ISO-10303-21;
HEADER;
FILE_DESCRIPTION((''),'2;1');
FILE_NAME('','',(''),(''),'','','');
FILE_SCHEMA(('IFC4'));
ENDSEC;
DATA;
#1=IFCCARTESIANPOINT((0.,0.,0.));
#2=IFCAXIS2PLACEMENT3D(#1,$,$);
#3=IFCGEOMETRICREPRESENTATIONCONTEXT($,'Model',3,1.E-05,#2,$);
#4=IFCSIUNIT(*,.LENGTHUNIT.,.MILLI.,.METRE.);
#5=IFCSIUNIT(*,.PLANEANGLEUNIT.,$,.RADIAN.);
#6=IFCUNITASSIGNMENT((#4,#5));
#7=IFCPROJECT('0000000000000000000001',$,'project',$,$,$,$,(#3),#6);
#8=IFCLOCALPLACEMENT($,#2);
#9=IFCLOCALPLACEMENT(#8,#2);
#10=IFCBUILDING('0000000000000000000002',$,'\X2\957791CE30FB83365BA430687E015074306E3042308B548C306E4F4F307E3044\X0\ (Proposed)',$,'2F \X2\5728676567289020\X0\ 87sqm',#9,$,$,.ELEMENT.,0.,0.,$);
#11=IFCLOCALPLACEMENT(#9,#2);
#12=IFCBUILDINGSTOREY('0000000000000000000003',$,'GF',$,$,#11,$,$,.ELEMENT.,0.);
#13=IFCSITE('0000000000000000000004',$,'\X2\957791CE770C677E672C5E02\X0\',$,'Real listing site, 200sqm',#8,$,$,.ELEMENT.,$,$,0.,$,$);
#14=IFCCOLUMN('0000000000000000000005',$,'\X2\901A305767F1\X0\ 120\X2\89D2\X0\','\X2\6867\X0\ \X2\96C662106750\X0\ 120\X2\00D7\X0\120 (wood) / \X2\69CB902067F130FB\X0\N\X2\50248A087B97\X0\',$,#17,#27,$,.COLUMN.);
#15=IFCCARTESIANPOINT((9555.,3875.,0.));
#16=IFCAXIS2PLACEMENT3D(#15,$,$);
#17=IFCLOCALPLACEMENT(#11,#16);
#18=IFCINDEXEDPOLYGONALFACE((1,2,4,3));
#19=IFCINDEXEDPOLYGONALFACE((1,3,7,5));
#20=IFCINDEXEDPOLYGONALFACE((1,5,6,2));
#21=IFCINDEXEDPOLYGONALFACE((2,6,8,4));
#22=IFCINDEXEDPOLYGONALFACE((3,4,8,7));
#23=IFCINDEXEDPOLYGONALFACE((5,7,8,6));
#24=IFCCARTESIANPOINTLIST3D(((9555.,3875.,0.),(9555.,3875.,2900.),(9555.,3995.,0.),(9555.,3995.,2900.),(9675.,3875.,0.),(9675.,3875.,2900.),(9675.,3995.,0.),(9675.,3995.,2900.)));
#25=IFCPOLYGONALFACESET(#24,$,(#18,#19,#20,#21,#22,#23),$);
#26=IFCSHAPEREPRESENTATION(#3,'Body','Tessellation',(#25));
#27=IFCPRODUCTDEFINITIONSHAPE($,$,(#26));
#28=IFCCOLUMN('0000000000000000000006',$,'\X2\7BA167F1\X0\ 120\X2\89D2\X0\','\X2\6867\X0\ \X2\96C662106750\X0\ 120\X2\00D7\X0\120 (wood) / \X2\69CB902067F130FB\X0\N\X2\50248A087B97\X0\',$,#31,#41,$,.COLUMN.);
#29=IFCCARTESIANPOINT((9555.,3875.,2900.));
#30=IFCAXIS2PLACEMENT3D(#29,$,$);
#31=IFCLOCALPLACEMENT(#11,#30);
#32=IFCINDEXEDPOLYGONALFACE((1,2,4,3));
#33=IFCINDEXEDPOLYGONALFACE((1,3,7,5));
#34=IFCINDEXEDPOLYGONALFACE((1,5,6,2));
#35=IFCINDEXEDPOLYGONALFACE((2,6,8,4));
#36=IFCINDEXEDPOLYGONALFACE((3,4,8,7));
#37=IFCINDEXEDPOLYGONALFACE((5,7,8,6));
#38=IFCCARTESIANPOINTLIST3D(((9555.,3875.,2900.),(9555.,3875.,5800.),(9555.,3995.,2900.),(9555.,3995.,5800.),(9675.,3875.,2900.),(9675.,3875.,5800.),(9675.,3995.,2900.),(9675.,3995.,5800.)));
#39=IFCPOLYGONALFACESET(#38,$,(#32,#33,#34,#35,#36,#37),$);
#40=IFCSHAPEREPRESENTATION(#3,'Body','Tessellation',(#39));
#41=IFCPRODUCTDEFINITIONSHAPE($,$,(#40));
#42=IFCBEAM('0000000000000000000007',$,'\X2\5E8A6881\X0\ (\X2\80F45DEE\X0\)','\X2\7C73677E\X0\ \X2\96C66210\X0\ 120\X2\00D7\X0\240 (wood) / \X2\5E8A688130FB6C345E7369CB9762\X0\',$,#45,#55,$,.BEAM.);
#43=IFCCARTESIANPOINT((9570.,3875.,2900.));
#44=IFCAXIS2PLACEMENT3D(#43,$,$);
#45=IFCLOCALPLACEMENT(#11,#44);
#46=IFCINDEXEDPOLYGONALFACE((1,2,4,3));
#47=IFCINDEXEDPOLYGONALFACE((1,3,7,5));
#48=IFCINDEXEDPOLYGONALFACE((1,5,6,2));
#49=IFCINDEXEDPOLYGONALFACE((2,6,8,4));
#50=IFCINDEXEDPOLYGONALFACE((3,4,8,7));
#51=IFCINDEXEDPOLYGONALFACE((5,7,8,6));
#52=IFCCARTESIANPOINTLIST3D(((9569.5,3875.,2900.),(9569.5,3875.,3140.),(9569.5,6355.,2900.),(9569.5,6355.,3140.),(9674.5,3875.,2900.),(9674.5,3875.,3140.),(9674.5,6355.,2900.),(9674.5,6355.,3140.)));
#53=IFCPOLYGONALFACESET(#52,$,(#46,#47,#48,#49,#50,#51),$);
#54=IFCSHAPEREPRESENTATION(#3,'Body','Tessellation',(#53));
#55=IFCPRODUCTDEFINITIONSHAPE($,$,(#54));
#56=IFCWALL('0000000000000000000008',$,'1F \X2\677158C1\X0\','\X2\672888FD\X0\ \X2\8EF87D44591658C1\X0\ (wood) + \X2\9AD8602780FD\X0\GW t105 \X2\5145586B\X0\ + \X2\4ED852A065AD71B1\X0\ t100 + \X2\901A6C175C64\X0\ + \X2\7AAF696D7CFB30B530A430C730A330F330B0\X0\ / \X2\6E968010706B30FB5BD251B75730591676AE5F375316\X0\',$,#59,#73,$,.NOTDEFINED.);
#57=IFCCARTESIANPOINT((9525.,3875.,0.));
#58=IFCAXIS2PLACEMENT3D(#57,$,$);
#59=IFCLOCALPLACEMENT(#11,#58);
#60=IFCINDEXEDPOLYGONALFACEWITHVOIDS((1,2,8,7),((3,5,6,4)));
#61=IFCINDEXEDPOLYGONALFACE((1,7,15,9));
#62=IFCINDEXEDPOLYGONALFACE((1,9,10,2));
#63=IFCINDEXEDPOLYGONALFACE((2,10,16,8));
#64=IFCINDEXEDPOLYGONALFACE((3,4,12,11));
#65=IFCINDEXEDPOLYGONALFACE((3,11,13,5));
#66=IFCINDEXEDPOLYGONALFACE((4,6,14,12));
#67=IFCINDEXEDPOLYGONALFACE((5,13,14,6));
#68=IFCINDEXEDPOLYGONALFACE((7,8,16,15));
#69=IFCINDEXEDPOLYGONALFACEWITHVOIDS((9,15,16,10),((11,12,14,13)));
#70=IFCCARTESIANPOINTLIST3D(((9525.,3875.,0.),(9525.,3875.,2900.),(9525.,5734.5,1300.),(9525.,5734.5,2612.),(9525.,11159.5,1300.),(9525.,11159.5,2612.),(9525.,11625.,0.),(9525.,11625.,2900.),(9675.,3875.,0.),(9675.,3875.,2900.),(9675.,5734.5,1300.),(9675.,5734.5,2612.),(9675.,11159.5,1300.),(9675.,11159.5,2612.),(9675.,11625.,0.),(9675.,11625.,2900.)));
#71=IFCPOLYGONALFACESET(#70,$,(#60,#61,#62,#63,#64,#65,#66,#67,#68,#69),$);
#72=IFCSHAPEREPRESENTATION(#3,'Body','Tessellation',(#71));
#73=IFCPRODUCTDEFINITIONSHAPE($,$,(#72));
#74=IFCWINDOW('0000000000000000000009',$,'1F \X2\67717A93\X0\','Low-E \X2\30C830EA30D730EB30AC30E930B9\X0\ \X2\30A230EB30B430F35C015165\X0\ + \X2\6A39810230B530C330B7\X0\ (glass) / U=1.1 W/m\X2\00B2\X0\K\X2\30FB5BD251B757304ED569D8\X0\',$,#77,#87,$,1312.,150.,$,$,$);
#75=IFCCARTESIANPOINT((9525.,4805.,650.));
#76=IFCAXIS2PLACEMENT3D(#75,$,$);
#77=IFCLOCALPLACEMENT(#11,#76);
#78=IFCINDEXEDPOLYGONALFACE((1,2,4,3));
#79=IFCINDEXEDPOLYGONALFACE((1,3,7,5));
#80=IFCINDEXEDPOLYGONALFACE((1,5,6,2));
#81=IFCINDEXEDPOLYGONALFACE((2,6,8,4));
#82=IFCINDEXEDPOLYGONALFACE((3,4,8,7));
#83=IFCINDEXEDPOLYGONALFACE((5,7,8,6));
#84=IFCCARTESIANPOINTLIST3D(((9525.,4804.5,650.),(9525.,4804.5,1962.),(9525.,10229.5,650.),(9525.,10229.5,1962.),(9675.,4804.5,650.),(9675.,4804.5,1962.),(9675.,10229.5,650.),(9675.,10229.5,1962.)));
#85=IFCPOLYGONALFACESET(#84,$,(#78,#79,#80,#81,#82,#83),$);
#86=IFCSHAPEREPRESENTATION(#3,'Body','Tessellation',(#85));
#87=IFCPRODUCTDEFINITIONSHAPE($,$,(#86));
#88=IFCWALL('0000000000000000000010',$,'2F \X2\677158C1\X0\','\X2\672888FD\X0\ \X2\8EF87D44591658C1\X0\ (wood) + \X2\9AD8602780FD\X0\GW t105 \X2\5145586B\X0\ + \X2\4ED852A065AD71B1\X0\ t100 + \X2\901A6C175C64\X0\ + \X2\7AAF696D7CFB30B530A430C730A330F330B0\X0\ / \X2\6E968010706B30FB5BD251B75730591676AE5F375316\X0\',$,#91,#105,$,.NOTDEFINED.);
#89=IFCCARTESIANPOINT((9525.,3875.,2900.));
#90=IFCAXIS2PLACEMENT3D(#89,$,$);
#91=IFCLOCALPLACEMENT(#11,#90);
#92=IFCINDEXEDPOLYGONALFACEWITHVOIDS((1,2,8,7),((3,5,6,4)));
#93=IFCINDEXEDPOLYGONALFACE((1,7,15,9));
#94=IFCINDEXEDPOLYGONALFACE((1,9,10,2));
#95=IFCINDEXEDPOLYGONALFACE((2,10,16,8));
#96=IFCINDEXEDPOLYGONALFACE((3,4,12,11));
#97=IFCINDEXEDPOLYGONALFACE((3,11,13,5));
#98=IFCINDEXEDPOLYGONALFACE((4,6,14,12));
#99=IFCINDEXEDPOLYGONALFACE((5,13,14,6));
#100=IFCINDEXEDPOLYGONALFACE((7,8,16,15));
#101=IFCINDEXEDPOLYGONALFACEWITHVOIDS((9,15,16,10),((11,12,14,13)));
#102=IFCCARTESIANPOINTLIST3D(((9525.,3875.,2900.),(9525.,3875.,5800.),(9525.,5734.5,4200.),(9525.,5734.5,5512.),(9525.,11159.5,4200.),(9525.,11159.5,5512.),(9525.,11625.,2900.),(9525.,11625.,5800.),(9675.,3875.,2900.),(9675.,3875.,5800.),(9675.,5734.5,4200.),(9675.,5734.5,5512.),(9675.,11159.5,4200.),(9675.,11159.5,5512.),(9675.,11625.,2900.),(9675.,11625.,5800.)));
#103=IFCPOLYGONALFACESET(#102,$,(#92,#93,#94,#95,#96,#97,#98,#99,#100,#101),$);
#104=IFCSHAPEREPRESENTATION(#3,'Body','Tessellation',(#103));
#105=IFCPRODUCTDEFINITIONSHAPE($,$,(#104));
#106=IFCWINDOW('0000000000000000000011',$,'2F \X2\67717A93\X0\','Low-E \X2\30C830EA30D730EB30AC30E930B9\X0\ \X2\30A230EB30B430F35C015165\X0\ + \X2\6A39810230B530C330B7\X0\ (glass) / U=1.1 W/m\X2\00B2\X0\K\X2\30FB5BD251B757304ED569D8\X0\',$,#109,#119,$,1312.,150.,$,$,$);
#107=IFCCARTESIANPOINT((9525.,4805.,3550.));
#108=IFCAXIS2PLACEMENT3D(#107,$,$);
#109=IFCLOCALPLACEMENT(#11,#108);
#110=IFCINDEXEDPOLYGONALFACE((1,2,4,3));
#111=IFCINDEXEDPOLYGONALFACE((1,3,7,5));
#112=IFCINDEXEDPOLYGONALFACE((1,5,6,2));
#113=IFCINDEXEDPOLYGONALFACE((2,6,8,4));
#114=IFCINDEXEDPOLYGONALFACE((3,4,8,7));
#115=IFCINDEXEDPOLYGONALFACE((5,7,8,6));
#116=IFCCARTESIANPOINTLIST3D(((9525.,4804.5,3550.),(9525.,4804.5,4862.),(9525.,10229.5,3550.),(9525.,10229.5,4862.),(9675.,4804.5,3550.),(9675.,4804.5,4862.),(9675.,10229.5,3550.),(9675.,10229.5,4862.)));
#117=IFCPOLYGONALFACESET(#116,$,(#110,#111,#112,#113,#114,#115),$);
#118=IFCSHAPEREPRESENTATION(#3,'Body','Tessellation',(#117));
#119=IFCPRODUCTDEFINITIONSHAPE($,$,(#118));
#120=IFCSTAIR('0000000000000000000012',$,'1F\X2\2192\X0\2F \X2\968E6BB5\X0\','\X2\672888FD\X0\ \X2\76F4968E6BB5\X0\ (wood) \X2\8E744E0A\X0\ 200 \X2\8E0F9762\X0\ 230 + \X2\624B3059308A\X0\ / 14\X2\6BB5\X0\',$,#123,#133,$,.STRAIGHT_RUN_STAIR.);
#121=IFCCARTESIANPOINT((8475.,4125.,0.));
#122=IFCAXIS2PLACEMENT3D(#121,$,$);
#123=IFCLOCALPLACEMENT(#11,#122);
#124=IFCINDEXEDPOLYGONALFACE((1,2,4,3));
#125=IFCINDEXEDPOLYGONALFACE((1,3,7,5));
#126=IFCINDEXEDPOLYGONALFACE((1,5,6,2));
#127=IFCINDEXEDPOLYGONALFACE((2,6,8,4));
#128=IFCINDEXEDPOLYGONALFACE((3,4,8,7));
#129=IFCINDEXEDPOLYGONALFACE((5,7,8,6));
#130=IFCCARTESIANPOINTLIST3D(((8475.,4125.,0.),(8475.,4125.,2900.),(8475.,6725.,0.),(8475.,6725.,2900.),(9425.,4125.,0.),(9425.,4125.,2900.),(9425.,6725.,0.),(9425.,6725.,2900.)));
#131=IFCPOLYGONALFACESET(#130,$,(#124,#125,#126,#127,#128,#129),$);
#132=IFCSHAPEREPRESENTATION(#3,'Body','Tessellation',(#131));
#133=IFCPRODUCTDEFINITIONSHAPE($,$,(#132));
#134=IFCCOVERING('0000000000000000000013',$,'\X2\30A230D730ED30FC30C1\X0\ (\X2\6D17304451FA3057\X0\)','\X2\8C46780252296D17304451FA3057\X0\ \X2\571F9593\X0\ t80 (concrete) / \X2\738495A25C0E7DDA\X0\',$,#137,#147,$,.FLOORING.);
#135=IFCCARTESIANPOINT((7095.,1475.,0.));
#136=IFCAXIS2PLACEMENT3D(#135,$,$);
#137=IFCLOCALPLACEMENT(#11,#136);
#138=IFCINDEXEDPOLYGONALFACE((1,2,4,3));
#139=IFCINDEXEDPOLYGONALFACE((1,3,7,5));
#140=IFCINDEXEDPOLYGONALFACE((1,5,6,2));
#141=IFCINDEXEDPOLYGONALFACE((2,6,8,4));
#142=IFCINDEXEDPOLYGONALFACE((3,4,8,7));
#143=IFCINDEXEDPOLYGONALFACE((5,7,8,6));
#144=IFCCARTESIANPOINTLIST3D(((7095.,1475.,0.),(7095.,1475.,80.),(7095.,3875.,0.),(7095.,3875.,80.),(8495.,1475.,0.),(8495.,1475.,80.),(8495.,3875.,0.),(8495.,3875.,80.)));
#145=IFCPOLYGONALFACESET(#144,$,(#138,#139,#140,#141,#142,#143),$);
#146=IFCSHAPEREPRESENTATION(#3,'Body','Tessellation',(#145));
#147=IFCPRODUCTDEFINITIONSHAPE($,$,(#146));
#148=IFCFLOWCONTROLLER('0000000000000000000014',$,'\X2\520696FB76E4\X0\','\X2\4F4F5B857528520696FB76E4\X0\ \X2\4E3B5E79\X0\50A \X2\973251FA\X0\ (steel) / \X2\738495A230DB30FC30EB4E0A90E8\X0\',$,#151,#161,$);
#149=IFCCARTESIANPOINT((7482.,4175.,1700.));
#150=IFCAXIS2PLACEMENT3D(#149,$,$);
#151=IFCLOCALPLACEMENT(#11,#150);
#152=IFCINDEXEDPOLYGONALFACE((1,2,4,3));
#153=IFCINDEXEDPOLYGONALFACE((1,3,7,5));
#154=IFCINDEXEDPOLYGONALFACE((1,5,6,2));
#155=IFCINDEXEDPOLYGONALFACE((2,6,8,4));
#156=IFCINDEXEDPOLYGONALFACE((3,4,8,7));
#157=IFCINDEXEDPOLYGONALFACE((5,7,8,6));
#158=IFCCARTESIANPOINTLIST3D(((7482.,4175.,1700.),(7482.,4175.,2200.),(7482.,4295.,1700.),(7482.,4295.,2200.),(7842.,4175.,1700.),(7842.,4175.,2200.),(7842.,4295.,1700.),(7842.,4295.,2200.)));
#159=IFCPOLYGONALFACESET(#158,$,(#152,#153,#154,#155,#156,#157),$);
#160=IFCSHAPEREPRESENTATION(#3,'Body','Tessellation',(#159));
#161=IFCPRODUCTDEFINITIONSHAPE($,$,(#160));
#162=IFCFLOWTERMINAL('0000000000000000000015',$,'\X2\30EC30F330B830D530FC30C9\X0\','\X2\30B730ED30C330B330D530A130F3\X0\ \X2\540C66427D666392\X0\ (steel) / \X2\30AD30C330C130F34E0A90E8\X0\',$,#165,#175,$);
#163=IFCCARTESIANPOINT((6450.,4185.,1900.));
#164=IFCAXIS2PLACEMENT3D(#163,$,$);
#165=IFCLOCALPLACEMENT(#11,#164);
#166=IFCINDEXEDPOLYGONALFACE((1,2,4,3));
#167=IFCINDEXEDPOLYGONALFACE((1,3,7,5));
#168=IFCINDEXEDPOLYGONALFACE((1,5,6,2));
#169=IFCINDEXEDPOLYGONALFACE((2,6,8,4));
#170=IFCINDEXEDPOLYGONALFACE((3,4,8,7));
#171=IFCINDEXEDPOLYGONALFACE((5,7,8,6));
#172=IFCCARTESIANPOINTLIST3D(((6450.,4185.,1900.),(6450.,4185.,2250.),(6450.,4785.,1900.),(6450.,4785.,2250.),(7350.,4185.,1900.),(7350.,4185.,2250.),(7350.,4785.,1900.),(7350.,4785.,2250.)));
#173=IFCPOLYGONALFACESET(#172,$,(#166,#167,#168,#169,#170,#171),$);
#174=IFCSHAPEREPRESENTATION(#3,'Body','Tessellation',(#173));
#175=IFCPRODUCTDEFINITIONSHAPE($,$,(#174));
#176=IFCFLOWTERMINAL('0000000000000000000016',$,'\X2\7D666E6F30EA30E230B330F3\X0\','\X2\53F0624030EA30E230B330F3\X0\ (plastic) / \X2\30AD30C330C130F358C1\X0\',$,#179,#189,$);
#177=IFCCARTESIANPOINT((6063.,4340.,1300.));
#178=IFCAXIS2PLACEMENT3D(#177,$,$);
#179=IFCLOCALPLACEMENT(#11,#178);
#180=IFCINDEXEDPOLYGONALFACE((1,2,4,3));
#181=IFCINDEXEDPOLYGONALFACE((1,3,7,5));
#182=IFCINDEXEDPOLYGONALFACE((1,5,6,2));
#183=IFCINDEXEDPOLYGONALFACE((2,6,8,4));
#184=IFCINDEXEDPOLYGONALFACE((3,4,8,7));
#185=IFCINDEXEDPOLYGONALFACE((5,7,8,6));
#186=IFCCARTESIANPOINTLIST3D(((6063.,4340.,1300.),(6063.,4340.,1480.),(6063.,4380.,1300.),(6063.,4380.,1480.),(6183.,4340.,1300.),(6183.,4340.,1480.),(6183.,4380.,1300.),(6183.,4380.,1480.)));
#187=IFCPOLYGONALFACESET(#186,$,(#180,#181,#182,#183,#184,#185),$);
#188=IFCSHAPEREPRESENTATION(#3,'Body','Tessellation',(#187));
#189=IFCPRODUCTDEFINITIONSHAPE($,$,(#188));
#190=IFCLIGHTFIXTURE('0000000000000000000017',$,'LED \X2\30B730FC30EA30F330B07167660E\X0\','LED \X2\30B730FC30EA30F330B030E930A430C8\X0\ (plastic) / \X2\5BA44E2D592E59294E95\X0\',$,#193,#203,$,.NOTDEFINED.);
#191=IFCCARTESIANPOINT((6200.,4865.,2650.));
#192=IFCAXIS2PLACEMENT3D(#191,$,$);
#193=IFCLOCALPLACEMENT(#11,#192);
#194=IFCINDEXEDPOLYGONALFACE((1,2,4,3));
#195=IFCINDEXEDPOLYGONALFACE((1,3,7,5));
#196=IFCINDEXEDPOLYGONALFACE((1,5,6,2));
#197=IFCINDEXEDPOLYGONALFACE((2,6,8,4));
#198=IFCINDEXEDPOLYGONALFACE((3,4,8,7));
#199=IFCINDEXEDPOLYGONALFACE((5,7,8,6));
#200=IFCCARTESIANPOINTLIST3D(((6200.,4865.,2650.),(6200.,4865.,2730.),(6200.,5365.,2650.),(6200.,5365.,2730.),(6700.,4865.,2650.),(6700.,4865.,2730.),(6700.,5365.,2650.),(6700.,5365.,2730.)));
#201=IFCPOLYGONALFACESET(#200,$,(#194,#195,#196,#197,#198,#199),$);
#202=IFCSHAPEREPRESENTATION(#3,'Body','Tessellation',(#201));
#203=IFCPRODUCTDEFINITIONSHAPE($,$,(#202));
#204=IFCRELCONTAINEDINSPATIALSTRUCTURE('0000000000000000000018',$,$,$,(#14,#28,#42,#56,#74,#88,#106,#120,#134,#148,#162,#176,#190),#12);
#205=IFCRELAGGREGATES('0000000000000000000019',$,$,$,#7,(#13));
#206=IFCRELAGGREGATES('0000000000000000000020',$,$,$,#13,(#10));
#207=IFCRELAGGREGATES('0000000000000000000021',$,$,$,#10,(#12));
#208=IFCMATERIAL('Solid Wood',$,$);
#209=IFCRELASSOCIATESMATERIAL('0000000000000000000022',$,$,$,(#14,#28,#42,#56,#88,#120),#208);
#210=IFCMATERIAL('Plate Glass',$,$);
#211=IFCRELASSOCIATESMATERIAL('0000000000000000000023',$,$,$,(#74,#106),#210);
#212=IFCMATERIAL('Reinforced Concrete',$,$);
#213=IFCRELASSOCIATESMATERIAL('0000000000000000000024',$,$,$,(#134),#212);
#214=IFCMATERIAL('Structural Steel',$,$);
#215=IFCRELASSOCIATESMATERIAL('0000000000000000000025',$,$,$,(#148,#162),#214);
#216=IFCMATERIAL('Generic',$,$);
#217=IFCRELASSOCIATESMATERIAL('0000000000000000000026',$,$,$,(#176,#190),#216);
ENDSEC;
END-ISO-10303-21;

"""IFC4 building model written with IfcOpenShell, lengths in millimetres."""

from ifc_helpers import new_model, si_unit, frame, frame_2d, origin, place, context, project, spatial, rectangle, extrude, material, element, fill, save


model = new_model("IFC4")

# Units and contexts
model_context = context("Model", 3, precision=1e-05, world=origin())
ifc_project = project(units=[si_unit("LENGTHUNIT", "METRE", prefix="MILLI"), si_unit("PLANEANGLEUNIT", "RADIAN")], contexts=[model_context])

# Site, building, storey
site_placement = place(None, origin())
site = spatial("IfcSite", under=ifc_project, at=site_placement, Name="長野県松本市", ObjectType="Real listing site, 200sqm", CompositionType="ELEMENT", RefElevation=0.0)
building_placement = place(site_placement, origin())
building = spatial("IfcBuilding", under=site, at=building_placement, Name="長野・茶室と縁側のある和の住まい (Proposed)", ObjectType="2F 在来木造 87sqm", CompositionType="ELEMENT", ElevationOfRefHeight=0.0, ElevationOfTerrain=0.0)
storey_placement = place(building_placement, origin())
storey = spatial("IfcBuildingStorey", under=building, at=storey_placement, Name="GF", CompositionType="ELEMENT", Elevation=0.0)

# Columns
ifc_material_1 = material(Name="Solid Wood")
column_1_placement = place(storey_placement, frame((9555.0, 3875.0, 0.0)))
element("IfcColumn", 1, at=column_1_placement, inside=storey, material=ifc_material_1, Name="通し柱 120角", Description="桧 集成材 120×120 (wood) / 構造柱・N値計算", PredefinedType="COLUMN", context=model_context, shape_type="SweptSolid", body=[
    extrude(rectangle(XDim=120.0, YDim=120.0, at=frame_2d((60.0, 60.0))), frame((9555.0, 3875.0, 0.0)), (0.0, 0.0, 1.0), 2900.0),
])
column_2_placement = place(storey_placement, frame((9555.0, 3875.0, 2900.0)))
element("IfcColumn", 2, at=column_2_placement, inside=storey, material=ifc_material_1, Name="管柱 120角", Description="桧 集成材 120×120 (wood) / 構造柱・N値計算", PredefinedType="COLUMN", context=model_context, shape_type="SweptSolid", body=[
    extrude(rectangle(XDim=120.0, YDim=120.0, at=frame_2d((60.0, 60.0))), frame((9555.0, 3875.0, 2900.0)), (0.0, 0.0, 1.0), 2900.0),
])

# Beam
beam_1_placement = place(storey_placement, frame((9570.0, 3875.0, 2900.0)))
element("IfcBeam", 3, at=beam_1_placement, inside=storey, material=ifc_material_1, Name="床梁 (胴差)", Description="米松 集成 120×240 (wood) / 床梁・水平構面", PredefinedType="BEAM", context=model_context, shape_type="SweptSolid", body=[
    extrude(rectangle(XDim=105.0, YDim=2480.0, at=frame_2d((52.0, 1240.0))), frame((9570.0, 3875.0, 2900.0)), (0.0, 0.0, 1.0), 240.0),
])

# Wall, opening, window
wall_1_placement = place(storey_placement, frame((9525.0, 3875.0, 0.0)))
wall_1 = element("IfcWall", 4, at=wall_1_placement, inside=storey, material=ifc_material_1, Name="1F 東壁", Description="木製 軸組外壁 (wood) + 高性能GW t105 充填 + 付加断熱 t100 + 通気層 + 窯業系サイディング / 準耐火・寒冷地外皮強化", PredefinedType="NOTDEFINED", context=model_context, shape_type="SweptSolid", body=[
    extrude(rectangle(XDim=150.0, YDim=7750.0, at=frame_2d((75.0, 3875.0))), frame((9525.0, 3875.0, 0.0)), (0.0, 0.0, 1.0), 2900.0),
])
opening_1_placement = place(storey_placement, frame((9525.0, 4805.0, 650.0)))
opening_1 = element("IfcOpeningElement", 5, at=opening_1_placement, cuts=wall_1, PredefinedType="NOTDEFINED", context=model_context, shape_type="SweptSolid", body=[
    extrude(rectangle(XDim=150.0, YDim=5425.0, at=frame_2d((75.0, 2712.0))), frame((9525.0, 4805.0, 650.0)), (0.0, 0.0, 1.0), 1312.0),
])
ifc_material_2 = material(Name="Plate Glass")
window_1_placement = place(storey_placement, frame((9525.0, 4805.0, 650.0)))
window_1 = element("IfcWindow", 6, at=window_1_placement, inside=storey, material=ifc_material_2, Name="1F 東窓", Description="Low-E トリプルガラス アルゴン封入 + 樹脂サッシ (glass) / U=1.1 W/m²K・寒冷地仕様", OverallHeight=1312.0, OverallWidth=150.0, context=model_context, shape_type="SweptSolid", body=[
    extrude(rectangle(XDim=150.0, YDim=5425.0, at=frame_2d((75.0, 2712.0))), frame((9525.0, 4805.0, 650.0)), (0.0, 0.0, 1.0), 1312.0),
])
fill(opening_1, window_1)

# Wall, opening, window
wall_2_placement = place(storey_placement, frame((9525.0, 3875.0, 2900.0)))
wall_2 = element("IfcWall", 7, at=wall_2_placement, inside=storey, material=ifc_material_1, Name="2F 東壁", Description="木製 軸組外壁 (wood) + 高性能GW t105 充填 + 付加断熱 t100 + 通気層 + 窯業系サイディング / 準耐火・寒冷地外皮強化", PredefinedType="NOTDEFINED", context=model_context, shape_type="SweptSolid", body=[
    extrude(rectangle(XDim=150.0, YDim=7750.0, at=frame_2d((75.0, 3875.0))), frame((9525.0, 3875.0, 2900.0)), (0.0, 0.0, 1.0), 2900.0),
])
opening_2_placement = place(storey_placement, frame((9525.0, 4805.0, 3550.0)))
opening_2 = element("IfcOpeningElement", 8, at=opening_2_placement, cuts=wall_2, PredefinedType="NOTDEFINED", context=model_context, shape_type="SweptSolid", body=[
    extrude(rectangle(XDim=150.0, YDim=5425.0, at=frame_2d((75.0, 2712.0))), frame((9525.0, 4805.0, 3550.0)), (0.0, 0.0, 1.0), 1312.0),
])
window_2_placement = place(storey_placement, frame((9525.0, 4805.0, 3550.0)))
window_2 = element("IfcWindow", 9, at=window_2_placement, inside=storey, material=ifc_material_2, Name="2F 東窓", Description="Low-E トリプルガラス アルゴン封入 + 樹脂サッシ (glass) / U=1.1 W/m²K・寒冷地仕様", OverallHeight=1312.0, OverallWidth=150.0, context=model_context, shape_type="SweptSolid", body=[
    extrude(rectangle(XDim=150.0, YDim=5425.0, at=frame_2d((75.0, 2712.0))), frame((9525.0, 4805.0, 3550.0)), (0.0, 0.0, 1.0), 1312.0),
])
fill(opening_2, window_2)

# Stair
stair_placement = place(storey_placement, frame((8475.0, 4125.0, 0.0)))
element("IfcStair", 10, at=stair_placement, inside=storey, material=ifc_material_1, Name="1F→2F 階段", Description="木製 直階段 (wood) 蹴上 200 踏面 230 + 手すり / 14段", PredefinedType="STRAIGHT_RUN_STAIR", context=model_context, shape_type="SweptSolid", body=[
    extrude(rectangle(XDim=950.0, YDim=2600.0, at=frame_2d((475.0, 1300.0))), frame((8475.0, 4125.0, 0.0)), (0.0, 0.0, 1.0), 2900.0),
])

# Covering
ifc_material_3 = material(Name="Reinforced Concrete")
covering_placement = place(storey_placement, frame((7095.0, 1475.0, 0.0)))
element("IfcCovering", 11, at=covering_placement, inside=storey, material=ifc_material_3, Name="アプローチ (洗い出し)", Description="豆砂利洗い出し 土間 t80 (concrete) / 玄関導線", PredefinedType="FLOORING", context=model_context, shape_type="SweptSolid", body=[
    extrude(rectangle(XDim=1400.0, YDim=2400.0, at=frame_2d((700.0, 1200.0))), frame((7095.0, 1475.0, 0.0)), (0.0, 0.0, 1.0), 80.0),
])

# Flow controller
ifc_material_4 = material(Name="Structural Steel")
flow_controller_placement = place(storey_placement, frame((7482.0, 4175.0, 1700.0)))
element("IfcFlowController", 12, at=flow_controller_placement, inside=storey, material=ifc_material_4, Name="分電盤", Description="住宅用分電盤 主幹50A 露出 (steel) / 玄関ホール上部", context=model_context, shape_type="SweptSolid", body=[
    extrude(rectangle(XDim=360.0, YDim=120.0, at=frame_2d((180.0, 60.0))), frame((7482.0, 4175.0, 1700.0)), (0.0, 0.0, 1.0), 500.0),
])

# Flow terminals
flow_terminal_1_placement = place(storey_placement, frame((6450.0, 4185.0, 1900.0)))
element("IfcFlowTerminal", 13, at=flow_terminal_1_placement, inside=storey, material=ifc_material_4, Name="レンジフード", Description="シロッコファン 同時給排 (steel) / キッチン上部", context=model_context, shape_type="SweptSolid", body=[
    extrude(rectangle(XDim=900.0, YDim=600.0, at=frame_2d((450.0, 300.0))), frame((6450.0, 4185.0, 1900.0)), (0.0, 0.0, 1.0), 350.0),
])
ifc_material_5 = material(Name="Generic")
flow_terminal_2_placement = place(storey_placement, frame((6063.0, 4340.0, 1300.0)))
element("IfcFlowTerminal", 14, at=flow_terminal_2_placement, inside=storey, material=ifc_material_5, Name="給湯リモコン", Description="台所リモコン (plastic) / キッチン壁", context=model_context, shape_type="SweptSolid", body=[
    extrude(rectangle(XDim=120.0, YDim=40.0, at=frame_2d((60.0, 20.0))), frame((6063.0, 4340.0, 1300.0)), (0.0, 0.0, 1.0), 180.0),
])

# Light fixture
light_fixture_1_placement = place(storey_placement, frame((6200.0, 4865.0, 2650.0)))
element("IfcLightFixture", 15, at=light_fixture_1_placement, inside=storey, material=ifc_material_5, Name="LED シーリング照明", Description="LED シーリングライト (plastic) / 室中央天井", PredefinedType="NOTDEFINED", context=model_context, shape_type="SweptSolid", body=[
    extrude(rectangle(XDim=500.0, YDim=500.0, at=frame_2d((250.0, 250.0))), frame((6200.0, 4865.0, 2650.0)), (0.0, 0.0, 1.0), 80.0),
])

save(model, "model.ifc")
